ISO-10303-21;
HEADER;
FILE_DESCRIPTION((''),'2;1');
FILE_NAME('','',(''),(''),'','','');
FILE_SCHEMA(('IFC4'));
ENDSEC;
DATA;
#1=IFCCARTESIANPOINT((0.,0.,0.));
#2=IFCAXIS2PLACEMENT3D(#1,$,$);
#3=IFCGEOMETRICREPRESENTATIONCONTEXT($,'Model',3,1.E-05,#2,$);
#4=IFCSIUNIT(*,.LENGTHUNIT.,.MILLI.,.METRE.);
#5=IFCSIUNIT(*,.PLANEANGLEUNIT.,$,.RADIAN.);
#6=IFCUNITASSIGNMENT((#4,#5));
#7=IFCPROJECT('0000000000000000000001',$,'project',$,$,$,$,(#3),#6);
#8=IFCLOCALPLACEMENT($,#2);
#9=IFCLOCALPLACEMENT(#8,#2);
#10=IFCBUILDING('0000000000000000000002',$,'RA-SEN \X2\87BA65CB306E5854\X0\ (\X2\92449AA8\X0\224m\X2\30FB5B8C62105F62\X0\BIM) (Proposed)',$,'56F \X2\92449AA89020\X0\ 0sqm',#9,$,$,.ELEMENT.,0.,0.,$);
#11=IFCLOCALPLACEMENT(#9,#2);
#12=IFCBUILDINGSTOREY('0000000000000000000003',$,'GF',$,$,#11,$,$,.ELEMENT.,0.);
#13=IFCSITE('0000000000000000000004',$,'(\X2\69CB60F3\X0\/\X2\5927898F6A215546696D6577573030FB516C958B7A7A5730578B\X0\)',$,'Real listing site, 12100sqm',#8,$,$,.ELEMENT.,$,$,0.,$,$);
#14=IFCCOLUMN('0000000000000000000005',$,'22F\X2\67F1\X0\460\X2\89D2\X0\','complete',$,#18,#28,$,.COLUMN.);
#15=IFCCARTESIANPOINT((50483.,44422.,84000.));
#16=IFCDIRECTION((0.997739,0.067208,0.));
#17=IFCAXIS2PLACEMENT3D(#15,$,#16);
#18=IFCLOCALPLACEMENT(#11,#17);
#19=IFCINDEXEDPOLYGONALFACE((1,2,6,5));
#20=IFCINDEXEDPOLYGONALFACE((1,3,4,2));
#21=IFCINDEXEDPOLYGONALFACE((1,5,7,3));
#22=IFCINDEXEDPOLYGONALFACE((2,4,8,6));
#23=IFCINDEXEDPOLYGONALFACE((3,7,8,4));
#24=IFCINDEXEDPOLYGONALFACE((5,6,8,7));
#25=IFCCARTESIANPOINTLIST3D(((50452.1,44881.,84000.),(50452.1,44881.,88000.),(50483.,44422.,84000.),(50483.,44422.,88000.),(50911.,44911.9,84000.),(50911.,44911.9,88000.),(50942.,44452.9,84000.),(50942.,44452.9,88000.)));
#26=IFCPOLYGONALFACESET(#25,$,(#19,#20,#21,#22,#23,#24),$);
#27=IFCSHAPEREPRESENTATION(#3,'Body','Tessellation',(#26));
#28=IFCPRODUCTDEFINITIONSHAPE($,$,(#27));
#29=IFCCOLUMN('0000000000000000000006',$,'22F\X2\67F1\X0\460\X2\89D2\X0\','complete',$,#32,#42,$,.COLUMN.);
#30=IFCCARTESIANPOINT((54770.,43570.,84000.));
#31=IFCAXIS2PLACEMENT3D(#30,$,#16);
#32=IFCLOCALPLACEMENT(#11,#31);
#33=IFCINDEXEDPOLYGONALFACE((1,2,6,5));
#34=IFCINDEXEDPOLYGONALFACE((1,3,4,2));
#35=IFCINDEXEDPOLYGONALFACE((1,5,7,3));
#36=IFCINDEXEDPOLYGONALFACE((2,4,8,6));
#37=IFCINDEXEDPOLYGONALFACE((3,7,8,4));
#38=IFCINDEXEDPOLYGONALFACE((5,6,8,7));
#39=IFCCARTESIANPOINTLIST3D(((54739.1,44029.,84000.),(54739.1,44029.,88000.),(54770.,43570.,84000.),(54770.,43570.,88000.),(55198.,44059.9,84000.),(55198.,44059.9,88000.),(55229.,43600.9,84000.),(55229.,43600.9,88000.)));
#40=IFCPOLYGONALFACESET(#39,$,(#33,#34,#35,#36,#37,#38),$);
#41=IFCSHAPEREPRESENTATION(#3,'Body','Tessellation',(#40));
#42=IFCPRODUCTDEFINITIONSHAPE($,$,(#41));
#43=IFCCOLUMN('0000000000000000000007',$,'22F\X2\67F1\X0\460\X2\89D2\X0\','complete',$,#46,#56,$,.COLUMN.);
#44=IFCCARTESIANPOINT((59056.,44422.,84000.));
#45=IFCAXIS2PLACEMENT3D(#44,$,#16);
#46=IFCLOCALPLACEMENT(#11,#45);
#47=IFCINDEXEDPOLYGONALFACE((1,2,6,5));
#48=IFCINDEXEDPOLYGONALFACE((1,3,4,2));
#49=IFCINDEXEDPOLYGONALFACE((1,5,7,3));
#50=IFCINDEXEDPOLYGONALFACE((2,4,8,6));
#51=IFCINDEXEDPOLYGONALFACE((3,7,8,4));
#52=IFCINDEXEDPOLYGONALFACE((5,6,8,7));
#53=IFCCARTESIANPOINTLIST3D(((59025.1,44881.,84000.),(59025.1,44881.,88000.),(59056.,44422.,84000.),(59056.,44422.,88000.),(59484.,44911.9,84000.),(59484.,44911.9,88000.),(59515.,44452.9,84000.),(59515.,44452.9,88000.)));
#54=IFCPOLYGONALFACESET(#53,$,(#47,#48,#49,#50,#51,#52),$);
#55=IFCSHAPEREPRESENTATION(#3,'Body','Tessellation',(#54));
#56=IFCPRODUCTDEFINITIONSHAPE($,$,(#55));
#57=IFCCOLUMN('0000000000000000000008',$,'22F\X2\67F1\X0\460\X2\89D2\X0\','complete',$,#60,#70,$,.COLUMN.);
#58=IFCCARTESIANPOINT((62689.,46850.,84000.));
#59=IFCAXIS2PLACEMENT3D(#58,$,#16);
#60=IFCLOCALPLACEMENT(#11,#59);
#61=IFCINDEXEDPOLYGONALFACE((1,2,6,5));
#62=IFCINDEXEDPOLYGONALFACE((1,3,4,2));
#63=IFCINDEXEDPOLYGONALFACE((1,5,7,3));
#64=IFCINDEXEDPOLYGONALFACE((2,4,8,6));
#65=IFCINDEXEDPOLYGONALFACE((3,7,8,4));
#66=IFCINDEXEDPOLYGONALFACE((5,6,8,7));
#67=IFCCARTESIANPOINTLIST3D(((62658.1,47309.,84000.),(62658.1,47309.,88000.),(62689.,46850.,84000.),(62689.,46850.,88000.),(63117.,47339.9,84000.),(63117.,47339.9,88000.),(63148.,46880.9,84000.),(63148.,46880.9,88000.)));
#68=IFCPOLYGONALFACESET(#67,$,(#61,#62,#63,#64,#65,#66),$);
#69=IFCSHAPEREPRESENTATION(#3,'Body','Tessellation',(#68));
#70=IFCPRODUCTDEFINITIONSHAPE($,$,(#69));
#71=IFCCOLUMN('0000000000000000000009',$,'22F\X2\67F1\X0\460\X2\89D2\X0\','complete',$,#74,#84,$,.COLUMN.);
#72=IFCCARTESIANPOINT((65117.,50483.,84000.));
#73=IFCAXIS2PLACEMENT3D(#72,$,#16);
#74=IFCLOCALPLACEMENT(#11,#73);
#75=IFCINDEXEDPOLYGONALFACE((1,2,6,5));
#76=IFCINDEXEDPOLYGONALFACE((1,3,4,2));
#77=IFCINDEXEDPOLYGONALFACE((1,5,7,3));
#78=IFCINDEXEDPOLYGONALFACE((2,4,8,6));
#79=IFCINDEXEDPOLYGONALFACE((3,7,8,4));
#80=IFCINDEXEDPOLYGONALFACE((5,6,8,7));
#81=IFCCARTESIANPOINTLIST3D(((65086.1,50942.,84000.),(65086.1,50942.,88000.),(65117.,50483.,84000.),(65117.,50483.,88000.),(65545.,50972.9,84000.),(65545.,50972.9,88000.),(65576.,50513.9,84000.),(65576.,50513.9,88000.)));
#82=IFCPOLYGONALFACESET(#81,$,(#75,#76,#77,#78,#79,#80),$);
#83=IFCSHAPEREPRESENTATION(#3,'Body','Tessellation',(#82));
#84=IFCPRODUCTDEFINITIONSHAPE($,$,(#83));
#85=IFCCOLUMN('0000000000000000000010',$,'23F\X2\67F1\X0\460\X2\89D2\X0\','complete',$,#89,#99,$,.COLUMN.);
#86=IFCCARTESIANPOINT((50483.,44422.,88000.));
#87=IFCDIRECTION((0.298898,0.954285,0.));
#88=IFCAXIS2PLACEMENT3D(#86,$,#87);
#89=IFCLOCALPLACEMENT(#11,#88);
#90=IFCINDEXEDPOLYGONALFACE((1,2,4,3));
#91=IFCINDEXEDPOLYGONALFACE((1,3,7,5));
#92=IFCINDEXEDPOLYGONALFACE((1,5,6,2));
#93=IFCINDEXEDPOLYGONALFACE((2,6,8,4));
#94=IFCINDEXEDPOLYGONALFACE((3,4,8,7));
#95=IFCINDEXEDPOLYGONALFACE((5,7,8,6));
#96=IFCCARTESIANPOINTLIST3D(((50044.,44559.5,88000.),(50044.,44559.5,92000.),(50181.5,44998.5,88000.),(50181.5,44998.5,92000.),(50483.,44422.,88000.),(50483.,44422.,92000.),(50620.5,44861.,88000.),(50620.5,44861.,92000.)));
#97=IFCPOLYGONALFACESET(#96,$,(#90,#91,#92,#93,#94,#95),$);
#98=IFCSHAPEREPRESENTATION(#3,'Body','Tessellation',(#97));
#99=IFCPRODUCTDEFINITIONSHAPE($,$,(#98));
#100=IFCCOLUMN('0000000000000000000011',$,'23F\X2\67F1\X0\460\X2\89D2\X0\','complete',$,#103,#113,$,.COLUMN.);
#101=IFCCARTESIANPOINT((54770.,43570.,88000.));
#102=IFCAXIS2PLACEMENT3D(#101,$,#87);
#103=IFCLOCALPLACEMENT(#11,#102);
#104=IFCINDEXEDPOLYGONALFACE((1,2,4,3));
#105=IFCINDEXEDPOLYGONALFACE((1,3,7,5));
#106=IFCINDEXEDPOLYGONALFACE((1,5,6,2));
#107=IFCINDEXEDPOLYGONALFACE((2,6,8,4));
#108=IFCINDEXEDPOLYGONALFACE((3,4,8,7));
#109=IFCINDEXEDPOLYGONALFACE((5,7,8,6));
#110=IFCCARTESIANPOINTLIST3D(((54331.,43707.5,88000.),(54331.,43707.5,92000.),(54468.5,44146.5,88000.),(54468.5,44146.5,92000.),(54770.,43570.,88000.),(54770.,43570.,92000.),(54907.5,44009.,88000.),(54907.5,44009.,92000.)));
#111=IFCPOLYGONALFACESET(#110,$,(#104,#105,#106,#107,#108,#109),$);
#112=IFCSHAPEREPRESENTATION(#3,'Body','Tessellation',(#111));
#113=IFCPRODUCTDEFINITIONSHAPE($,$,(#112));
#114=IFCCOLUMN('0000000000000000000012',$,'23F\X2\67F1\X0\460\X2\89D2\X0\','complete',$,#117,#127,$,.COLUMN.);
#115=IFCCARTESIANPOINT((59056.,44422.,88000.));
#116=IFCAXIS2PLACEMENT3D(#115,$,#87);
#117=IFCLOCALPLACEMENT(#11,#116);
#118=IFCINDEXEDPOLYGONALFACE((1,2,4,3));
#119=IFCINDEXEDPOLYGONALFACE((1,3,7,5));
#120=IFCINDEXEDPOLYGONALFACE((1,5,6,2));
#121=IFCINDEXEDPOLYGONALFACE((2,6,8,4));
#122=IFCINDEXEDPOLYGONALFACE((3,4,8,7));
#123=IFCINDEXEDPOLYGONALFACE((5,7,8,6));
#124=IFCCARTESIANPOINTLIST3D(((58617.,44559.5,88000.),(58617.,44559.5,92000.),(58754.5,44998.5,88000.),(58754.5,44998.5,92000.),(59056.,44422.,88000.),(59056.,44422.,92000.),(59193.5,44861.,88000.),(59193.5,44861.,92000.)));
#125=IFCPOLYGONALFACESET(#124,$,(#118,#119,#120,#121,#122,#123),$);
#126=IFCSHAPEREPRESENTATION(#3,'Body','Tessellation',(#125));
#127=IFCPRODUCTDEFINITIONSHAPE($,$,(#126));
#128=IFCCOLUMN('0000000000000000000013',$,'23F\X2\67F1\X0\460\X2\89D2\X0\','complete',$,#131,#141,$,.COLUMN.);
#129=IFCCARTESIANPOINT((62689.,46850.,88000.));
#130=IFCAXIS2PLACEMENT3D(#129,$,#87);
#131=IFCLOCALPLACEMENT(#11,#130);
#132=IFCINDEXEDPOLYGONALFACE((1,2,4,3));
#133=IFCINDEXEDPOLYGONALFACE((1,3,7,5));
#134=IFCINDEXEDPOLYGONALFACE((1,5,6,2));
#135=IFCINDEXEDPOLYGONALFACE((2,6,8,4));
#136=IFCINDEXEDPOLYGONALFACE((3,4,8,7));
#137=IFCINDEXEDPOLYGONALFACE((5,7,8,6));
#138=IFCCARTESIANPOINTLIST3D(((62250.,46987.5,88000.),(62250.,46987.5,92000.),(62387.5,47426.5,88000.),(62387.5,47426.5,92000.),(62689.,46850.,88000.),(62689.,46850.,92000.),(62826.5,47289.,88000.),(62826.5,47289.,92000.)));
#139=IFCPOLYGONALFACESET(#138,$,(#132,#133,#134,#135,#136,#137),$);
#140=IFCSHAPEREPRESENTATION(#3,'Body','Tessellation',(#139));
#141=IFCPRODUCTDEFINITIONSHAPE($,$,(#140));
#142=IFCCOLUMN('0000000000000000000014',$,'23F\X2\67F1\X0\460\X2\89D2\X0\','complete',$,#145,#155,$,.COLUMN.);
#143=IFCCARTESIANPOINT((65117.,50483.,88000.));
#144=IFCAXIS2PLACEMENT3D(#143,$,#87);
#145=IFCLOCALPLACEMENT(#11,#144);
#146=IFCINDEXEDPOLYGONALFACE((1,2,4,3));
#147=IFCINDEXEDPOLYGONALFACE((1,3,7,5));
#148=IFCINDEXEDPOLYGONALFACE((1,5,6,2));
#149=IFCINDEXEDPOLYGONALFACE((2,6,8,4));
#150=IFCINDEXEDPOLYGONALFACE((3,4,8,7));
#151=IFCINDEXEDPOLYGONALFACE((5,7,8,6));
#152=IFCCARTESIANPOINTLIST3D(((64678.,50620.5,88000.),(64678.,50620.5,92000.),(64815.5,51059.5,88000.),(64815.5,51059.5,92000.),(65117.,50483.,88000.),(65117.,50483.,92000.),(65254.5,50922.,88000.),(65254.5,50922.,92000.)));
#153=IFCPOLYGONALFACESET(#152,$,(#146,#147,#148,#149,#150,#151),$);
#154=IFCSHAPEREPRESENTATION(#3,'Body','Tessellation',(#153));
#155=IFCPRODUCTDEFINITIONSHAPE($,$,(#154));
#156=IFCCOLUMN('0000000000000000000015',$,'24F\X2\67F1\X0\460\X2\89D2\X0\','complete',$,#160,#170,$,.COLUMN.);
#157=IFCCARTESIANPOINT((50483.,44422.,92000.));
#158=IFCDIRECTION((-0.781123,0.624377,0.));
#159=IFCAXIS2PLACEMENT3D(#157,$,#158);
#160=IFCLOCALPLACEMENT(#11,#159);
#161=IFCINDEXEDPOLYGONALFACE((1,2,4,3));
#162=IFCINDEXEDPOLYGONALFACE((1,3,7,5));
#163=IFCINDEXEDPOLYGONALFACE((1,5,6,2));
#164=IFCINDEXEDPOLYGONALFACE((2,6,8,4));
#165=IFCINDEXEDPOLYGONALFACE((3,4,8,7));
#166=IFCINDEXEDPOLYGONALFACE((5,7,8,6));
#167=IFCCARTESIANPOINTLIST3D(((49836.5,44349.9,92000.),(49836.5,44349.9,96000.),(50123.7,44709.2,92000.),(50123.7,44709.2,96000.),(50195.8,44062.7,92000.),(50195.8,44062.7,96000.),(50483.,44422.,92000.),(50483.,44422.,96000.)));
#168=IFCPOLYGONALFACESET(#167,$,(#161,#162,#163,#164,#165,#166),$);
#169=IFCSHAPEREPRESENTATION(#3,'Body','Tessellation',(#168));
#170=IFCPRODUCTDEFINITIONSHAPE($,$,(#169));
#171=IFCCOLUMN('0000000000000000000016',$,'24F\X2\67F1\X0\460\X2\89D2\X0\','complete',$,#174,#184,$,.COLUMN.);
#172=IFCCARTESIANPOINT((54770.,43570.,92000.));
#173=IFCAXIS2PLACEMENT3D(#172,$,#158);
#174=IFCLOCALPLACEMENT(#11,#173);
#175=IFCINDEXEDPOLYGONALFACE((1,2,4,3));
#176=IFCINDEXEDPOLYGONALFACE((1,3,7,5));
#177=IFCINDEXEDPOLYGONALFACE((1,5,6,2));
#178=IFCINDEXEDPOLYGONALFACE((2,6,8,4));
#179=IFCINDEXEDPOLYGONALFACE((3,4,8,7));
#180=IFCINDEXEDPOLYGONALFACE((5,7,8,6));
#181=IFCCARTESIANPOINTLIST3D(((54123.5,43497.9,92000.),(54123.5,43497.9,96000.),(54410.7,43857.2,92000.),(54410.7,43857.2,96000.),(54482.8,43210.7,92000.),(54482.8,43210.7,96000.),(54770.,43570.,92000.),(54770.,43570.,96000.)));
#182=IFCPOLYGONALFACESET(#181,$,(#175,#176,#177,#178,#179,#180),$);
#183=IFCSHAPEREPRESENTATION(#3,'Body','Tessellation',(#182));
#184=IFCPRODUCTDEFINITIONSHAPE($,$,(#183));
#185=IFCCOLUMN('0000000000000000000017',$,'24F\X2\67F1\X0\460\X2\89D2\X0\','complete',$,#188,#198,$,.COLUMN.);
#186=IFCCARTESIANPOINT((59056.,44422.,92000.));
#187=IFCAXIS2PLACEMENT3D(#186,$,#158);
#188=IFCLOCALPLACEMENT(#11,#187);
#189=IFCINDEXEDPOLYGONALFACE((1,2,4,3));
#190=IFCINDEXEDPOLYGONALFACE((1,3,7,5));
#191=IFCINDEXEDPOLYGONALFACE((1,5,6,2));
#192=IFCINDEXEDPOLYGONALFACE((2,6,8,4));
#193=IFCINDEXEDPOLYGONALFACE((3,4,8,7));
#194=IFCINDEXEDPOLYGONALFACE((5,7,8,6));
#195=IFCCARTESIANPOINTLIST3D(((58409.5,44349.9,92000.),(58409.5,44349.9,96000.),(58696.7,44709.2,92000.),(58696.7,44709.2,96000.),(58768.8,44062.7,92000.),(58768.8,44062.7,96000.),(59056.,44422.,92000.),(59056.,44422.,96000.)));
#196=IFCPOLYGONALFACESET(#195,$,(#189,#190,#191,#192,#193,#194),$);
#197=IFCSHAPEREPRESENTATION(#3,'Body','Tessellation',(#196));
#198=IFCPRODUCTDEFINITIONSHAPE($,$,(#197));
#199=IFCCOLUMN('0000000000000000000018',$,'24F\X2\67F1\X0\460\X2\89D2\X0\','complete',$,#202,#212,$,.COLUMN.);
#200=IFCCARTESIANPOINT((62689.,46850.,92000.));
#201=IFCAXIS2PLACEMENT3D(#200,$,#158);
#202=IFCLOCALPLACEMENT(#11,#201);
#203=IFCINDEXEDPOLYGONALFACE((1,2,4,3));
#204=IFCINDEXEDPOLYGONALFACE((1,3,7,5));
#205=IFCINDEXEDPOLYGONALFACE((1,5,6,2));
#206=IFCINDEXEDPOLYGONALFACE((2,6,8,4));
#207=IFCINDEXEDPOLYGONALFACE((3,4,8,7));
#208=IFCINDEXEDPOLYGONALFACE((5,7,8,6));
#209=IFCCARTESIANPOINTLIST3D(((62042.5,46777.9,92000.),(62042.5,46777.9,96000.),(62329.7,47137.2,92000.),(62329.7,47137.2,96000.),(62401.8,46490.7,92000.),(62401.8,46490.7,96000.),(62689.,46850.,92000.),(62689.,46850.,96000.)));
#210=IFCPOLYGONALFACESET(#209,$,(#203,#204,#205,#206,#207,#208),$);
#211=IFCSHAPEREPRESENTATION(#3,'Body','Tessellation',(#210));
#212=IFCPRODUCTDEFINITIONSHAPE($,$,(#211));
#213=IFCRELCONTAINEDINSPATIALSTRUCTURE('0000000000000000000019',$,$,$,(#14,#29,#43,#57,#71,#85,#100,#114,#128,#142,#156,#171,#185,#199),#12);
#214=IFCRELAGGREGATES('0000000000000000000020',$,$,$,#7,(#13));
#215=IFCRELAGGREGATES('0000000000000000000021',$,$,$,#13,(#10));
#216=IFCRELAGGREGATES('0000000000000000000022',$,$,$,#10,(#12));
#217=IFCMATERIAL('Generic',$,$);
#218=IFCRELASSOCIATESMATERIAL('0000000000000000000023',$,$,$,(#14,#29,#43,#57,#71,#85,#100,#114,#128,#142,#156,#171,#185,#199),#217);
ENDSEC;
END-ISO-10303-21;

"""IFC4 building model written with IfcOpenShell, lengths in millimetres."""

from ifc_helpers import new_model, si_unit, frame, frame_2d, origin, place, context, project, spatial, rectangle, extrude, material, element, save


model = new_model("IFC4")

# Units and contexts
model_context = context("Model", 3, precision=1e-05, world=origin())
ifc_project = project(units=[si_unit("LENGTHUNIT", "METRE", prefix="MILLI"), si_unit("PLANEANGLEUNIT", "RADIAN")], contexts=[model_context])

# Site, building, storey
site_placement = place(None, origin())
site = spatial("IfcSite", under=ifc_project, at=site_placement, Name="(構想/大規模商業敷地・公開空地型)", ObjectType="Real listing site, 12100sqm", CompositionType="ELEMENT", RefElevation=0.0)
building_placement = place(site_placement, origin())
building = spatial("IfcBuilding", under=site, at=building_placement, Name="RA-SEN 螺旋の塔 (鉄骨224m・完成形BIM) (Proposed)", ObjectType="56F 鉄骨造 0sqm", CompositionType="ELEMENT", ElevationOfRefHeight=0.0, ElevationOfTerrain=0.0)
storey_placement = place(building_placement, origin())
storey = spatial("IfcBuildingStorey", under=building, at=storey_placement, Name="GF", CompositionType="ELEMENT", Elevation=0.0)

# Columns
ifc_material = material(Name="Generic")
column_1_placement = place(storey_placement, frame((50483.0, 44422.0, 84000.0), x_axis=(0.997739, 0.067208, 0.0)))
element("IfcColumn", 1, at=column_1_placement, inside=storey, material=ifc_material, Name="22F柱460角", Description="complete", PredefinedType="COLUMN", context=model_context, shape_type="SweptSolid", body=[
    extrude(rectangle(XDim=460.0, YDim=460.0, at=frame_2d((230.0, 230.0))), frame((50483.0, 44422.0, 84000.0), x_axis=(0.997739, 0.067208, 0.0)), (0.0, 0.0, 1.0), 4000.0),
])
column_2_placement = place(storey_placement, frame((54770.0, 43570.0, 84000.0), x_axis=(0.997739, 0.067208, 0.0)))
element("IfcColumn", 2, at=column_2_placement, inside=storey, material=ifc_material, Name="22F柱460角", Description="complete", PredefinedType="COLUMN", context=model_context, shape_type="SweptSolid", body=[
    extrude(rectangle(XDim=460.0, YDim=460.0, at=frame_2d((230.0, 230.0))), frame((54770.0, 43570.0, 84000.0), x_axis=(0.997739, 0.067208, 0.0)), (0.0, 0.0, 1.0), 4000.0),
])
column_3_placement = place(storey_placement, frame((59056.0, 44422.0, 84000.0), x_axis=(0.997739, 0.067208, 0.0)))
element("IfcColumn", 3, at=column_3_placement, inside=storey, material=ifc_material, Name="22F柱460角", Description="complete", PredefinedType="COLUMN", context=model_context, shape_type="SweptSolid", body=[
    extrude(rectangle(XDim=460.0, YDim=460.0, at=frame_2d((230.0, 230.0))), frame((59056.0, 44422.0, 84000.0), x_axis=(0.997739, 0.067208, 0.0)), (0.0, 0.0, 1.0), 4000.0),
])
column_4_placement = place(storey_placement, frame((62689.0, 46850.0, 84000.0), x_axis=(0.997739, 0.067208, 0.0)))
element("IfcColumn", 4, at=column_4_placement, inside=storey, material=ifc_material, Name="22F柱460角", Description="complete", PredefinedType="COLUMN", context=model_context, shape_type="SweptSolid", body=[
    extrude(rectangle(XDim=460.0, YDim=460.0, at=frame_2d((230.0, 230.0))), frame((62689.0, 46850.0, 84000.0), x_axis=(0.997739, 0.067208, 0.0)), (0.0, 0.0, 1.0), 4000.0),
])
column_5_placement = place(storey_placement, frame((65117.0, 50483.0, 84000.0), x_axis=(0.997739, 0.067208, 0.0)))
element("IfcColumn", 5, at=column_5_placement, inside=storey, material=ifc_material, Name="22F柱460角", Description="complete", PredefinedType="COLUMN", context=model_context, shape_type="SweptSolid", body=[
    extrude(rectangle(XDim=460.0, YDim=460.0, at=frame_2d((230.0, 230.0))), frame((65117.0, 50483.0, 84000.0), x_axis=(0.997739, 0.067208, 0.0)), (0.0, 0.0, 1.0), 4000.0),
])
column_6_placement = place(storey_placement, frame((50483.0, 44422.0, 88000.0), x_axis=(0.298898, 0.954285, 0.0)))
element("IfcColumn", 6, at=column_6_placement, inside=storey, material=ifc_material, Name="23F柱460角", Description="complete", PredefinedType="COLUMN", context=model_context, shape_type="SweptSolid", body=[
    extrude(rectangle(XDim=460.0, YDim=460.0, at=frame_2d((230.0, 230.0))), frame((50483.0, 44422.0, 88000.0), x_axis=(0.298898, 0.954285, 0.0)), (0.0, 0.0, 1.0), 4000.0),
])
column_7_placement = place(storey_placement, frame((54770.0, 43570.0, 88000.0), x_axis=(0.298898, 0.954285, 0.0)))
element("IfcColumn", 7, at=column_7_placement, inside=storey, material=ifc_material, Name="23F柱460角", Description="complete", PredefinedType="COLUMN", context=model_context, shape_type="SweptSolid", body=[
    extrude(rectangle(XDim=460.0, YDim=460.0, at=frame_2d((230.0, 230.0))), frame((54770.0, 43570.0, 88000.0), x_axis=(0.298898, 0.954285, 0.0)), (0.0, 0.0, 1.0), 4000.0),
])
column_8_placement = place(storey_placement, frame((59056.0, 44422.0, 88000.0), x_axis=(0.298898, 0.954285, 0.0)))
element("IfcColumn", 8, at=column_8_placement, inside=storey, material=ifc_material, Name="23F柱460角", Description="complete", PredefinedType="COLUMN", context=model_context, shape_type="SweptSolid", body=[
    extrude(rectangle(XDim=460.0, YDim=460.0, at=frame_2d((230.0, 230.0))), frame((59056.0, 44422.0, 88000.0), x_axis=(0.298898, 0.954285, 0.0)), (0.0, 0.0, 1.0), 4000.0),
])
column_9_placement = place(storey_placement, frame((62689.0, 46850.0, 88000.0), x_axis=(0.298898, 0.954285, 0.0)))
element("IfcColumn", 9, at=column_9_placement, inside=storey, material=ifc_material, Name="23F柱460角", Description="complete", PredefinedType="COLUMN", context=model_context, shape_type="SweptSolid", body=[
    extrude(rectangle(XDim=460.0, YDim=460.0, at=frame_2d((230.0, 230.0))), frame((62689.0, 46850.0, 88000.0), x_axis=(0.298898, 0.954285, 0.0)), (0.0, 0.0, 1.0), 4000.0),
])
column_10_placement = place(storey_placement, frame((65117.0, 50483.0, 88000.0), x_axis=(0.298898, 0.954285, 0.0)))
element("IfcColumn", 10, at=column_10_placement, inside=storey, material=ifc_material, Name="23F柱460角", Description="complete", PredefinedType="COLUMN", context=model_context, shape_type="SweptSolid", body=[
    extrude(rectangle(XDim=460.0, YDim=460.0, at=frame_2d((230.0, 230.0))), frame((65117.0, 50483.0, 88000.0), x_axis=(0.298898, 0.954285, 0.0)), (0.0, 0.0, 1.0), 4000.0),
])
column_11_placement = place(storey_placement, frame((50483.0, 44422.0, 92000.0), x_axis=(-0.781123, 0.624377, 0.0)))
element("IfcColumn", 11, at=column_11_placement, inside=storey, material=ifc_material, Name="24F柱460角", Description="complete", PredefinedType="COLUMN", context=model_context, shape_type="SweptSolid", body=[
    extrude(rectangle(XDim=460.0, YDim=460.0, at=frame_2d((230.0, 230.0))), frame((50483.0, 44422.0, 92000.0), x_axis=(-0.781123, 0.624377, 0.0)), (0.0, 0.0, 1.0), 4000.0),
])
column_12_placement = place(storey_placement, frame((54770.0, 43570.0, 92000.0), x_axis=(-0.781123, 0.624377, 0.0)))
element("IfcColumn", 12, at=column_12_placement, inside=storey, material=ifc_material, Name="24F柱460角", Description="complete", PredefinedType="COLUMN", context=model_context, shape_type="SweptSolid", body=[
    extrude(rectangle(XDim=460.0, YDim=460.0, at=frame_2d((230.0, 230.0))), frame((54770.0, 43570.0, 92000.0), x_axis=(-0.781123, 0.624377, 0.0)), (0.0, 0.0, 1.0), 4000.0),
])
column_13_placement = place(storey_placement, frame((59056.0, 44422.0, 92000.0), x_axis=(-0.781123, 0.624377, 0.0)))
element("IfcColumn", 13, at=column_13_placement, inside=storey, material=ifc_material, Name="24F柱460角", Description="complete", PredefinedType="COLUMN", context=model_context, shape_type="SweptSolid", body=[
    extrude(rectangle(XDim=460.0, YDim=460.0, at=frame_2d((230.0, 230.0))), frame((59056.0, 44422.0, 92000.0), x_axis=(-0.781123, 0.624377, 0.0)), (0.0, 0.0, 1.0), 4000.0),
])
column_14_placement = place(storey_placement, frame((62689.0, 46850.0, 92000.0), x_axis=(-0.781123, 0.624377, 0.0)))
element("IfcColumn", 14, at=column_14_placement, inside=storey, material=ifc_material, Name="24F柱460角", Description="complete", PredefinedType="COLUMN", context=model_context, shape_type="SweptSolid", body=[
    extrude(rectangle(XDim=460.0, YDim=460.0, at=frame_2d((230.0, 230.0))), frame((62689.0, 46850.0, 92000.0), x_axis=(-0.781123, 0.624377, 0.0)), (0.0, 0.0, 1.0), 4000.0),
])

save(model, "model.ifc")
